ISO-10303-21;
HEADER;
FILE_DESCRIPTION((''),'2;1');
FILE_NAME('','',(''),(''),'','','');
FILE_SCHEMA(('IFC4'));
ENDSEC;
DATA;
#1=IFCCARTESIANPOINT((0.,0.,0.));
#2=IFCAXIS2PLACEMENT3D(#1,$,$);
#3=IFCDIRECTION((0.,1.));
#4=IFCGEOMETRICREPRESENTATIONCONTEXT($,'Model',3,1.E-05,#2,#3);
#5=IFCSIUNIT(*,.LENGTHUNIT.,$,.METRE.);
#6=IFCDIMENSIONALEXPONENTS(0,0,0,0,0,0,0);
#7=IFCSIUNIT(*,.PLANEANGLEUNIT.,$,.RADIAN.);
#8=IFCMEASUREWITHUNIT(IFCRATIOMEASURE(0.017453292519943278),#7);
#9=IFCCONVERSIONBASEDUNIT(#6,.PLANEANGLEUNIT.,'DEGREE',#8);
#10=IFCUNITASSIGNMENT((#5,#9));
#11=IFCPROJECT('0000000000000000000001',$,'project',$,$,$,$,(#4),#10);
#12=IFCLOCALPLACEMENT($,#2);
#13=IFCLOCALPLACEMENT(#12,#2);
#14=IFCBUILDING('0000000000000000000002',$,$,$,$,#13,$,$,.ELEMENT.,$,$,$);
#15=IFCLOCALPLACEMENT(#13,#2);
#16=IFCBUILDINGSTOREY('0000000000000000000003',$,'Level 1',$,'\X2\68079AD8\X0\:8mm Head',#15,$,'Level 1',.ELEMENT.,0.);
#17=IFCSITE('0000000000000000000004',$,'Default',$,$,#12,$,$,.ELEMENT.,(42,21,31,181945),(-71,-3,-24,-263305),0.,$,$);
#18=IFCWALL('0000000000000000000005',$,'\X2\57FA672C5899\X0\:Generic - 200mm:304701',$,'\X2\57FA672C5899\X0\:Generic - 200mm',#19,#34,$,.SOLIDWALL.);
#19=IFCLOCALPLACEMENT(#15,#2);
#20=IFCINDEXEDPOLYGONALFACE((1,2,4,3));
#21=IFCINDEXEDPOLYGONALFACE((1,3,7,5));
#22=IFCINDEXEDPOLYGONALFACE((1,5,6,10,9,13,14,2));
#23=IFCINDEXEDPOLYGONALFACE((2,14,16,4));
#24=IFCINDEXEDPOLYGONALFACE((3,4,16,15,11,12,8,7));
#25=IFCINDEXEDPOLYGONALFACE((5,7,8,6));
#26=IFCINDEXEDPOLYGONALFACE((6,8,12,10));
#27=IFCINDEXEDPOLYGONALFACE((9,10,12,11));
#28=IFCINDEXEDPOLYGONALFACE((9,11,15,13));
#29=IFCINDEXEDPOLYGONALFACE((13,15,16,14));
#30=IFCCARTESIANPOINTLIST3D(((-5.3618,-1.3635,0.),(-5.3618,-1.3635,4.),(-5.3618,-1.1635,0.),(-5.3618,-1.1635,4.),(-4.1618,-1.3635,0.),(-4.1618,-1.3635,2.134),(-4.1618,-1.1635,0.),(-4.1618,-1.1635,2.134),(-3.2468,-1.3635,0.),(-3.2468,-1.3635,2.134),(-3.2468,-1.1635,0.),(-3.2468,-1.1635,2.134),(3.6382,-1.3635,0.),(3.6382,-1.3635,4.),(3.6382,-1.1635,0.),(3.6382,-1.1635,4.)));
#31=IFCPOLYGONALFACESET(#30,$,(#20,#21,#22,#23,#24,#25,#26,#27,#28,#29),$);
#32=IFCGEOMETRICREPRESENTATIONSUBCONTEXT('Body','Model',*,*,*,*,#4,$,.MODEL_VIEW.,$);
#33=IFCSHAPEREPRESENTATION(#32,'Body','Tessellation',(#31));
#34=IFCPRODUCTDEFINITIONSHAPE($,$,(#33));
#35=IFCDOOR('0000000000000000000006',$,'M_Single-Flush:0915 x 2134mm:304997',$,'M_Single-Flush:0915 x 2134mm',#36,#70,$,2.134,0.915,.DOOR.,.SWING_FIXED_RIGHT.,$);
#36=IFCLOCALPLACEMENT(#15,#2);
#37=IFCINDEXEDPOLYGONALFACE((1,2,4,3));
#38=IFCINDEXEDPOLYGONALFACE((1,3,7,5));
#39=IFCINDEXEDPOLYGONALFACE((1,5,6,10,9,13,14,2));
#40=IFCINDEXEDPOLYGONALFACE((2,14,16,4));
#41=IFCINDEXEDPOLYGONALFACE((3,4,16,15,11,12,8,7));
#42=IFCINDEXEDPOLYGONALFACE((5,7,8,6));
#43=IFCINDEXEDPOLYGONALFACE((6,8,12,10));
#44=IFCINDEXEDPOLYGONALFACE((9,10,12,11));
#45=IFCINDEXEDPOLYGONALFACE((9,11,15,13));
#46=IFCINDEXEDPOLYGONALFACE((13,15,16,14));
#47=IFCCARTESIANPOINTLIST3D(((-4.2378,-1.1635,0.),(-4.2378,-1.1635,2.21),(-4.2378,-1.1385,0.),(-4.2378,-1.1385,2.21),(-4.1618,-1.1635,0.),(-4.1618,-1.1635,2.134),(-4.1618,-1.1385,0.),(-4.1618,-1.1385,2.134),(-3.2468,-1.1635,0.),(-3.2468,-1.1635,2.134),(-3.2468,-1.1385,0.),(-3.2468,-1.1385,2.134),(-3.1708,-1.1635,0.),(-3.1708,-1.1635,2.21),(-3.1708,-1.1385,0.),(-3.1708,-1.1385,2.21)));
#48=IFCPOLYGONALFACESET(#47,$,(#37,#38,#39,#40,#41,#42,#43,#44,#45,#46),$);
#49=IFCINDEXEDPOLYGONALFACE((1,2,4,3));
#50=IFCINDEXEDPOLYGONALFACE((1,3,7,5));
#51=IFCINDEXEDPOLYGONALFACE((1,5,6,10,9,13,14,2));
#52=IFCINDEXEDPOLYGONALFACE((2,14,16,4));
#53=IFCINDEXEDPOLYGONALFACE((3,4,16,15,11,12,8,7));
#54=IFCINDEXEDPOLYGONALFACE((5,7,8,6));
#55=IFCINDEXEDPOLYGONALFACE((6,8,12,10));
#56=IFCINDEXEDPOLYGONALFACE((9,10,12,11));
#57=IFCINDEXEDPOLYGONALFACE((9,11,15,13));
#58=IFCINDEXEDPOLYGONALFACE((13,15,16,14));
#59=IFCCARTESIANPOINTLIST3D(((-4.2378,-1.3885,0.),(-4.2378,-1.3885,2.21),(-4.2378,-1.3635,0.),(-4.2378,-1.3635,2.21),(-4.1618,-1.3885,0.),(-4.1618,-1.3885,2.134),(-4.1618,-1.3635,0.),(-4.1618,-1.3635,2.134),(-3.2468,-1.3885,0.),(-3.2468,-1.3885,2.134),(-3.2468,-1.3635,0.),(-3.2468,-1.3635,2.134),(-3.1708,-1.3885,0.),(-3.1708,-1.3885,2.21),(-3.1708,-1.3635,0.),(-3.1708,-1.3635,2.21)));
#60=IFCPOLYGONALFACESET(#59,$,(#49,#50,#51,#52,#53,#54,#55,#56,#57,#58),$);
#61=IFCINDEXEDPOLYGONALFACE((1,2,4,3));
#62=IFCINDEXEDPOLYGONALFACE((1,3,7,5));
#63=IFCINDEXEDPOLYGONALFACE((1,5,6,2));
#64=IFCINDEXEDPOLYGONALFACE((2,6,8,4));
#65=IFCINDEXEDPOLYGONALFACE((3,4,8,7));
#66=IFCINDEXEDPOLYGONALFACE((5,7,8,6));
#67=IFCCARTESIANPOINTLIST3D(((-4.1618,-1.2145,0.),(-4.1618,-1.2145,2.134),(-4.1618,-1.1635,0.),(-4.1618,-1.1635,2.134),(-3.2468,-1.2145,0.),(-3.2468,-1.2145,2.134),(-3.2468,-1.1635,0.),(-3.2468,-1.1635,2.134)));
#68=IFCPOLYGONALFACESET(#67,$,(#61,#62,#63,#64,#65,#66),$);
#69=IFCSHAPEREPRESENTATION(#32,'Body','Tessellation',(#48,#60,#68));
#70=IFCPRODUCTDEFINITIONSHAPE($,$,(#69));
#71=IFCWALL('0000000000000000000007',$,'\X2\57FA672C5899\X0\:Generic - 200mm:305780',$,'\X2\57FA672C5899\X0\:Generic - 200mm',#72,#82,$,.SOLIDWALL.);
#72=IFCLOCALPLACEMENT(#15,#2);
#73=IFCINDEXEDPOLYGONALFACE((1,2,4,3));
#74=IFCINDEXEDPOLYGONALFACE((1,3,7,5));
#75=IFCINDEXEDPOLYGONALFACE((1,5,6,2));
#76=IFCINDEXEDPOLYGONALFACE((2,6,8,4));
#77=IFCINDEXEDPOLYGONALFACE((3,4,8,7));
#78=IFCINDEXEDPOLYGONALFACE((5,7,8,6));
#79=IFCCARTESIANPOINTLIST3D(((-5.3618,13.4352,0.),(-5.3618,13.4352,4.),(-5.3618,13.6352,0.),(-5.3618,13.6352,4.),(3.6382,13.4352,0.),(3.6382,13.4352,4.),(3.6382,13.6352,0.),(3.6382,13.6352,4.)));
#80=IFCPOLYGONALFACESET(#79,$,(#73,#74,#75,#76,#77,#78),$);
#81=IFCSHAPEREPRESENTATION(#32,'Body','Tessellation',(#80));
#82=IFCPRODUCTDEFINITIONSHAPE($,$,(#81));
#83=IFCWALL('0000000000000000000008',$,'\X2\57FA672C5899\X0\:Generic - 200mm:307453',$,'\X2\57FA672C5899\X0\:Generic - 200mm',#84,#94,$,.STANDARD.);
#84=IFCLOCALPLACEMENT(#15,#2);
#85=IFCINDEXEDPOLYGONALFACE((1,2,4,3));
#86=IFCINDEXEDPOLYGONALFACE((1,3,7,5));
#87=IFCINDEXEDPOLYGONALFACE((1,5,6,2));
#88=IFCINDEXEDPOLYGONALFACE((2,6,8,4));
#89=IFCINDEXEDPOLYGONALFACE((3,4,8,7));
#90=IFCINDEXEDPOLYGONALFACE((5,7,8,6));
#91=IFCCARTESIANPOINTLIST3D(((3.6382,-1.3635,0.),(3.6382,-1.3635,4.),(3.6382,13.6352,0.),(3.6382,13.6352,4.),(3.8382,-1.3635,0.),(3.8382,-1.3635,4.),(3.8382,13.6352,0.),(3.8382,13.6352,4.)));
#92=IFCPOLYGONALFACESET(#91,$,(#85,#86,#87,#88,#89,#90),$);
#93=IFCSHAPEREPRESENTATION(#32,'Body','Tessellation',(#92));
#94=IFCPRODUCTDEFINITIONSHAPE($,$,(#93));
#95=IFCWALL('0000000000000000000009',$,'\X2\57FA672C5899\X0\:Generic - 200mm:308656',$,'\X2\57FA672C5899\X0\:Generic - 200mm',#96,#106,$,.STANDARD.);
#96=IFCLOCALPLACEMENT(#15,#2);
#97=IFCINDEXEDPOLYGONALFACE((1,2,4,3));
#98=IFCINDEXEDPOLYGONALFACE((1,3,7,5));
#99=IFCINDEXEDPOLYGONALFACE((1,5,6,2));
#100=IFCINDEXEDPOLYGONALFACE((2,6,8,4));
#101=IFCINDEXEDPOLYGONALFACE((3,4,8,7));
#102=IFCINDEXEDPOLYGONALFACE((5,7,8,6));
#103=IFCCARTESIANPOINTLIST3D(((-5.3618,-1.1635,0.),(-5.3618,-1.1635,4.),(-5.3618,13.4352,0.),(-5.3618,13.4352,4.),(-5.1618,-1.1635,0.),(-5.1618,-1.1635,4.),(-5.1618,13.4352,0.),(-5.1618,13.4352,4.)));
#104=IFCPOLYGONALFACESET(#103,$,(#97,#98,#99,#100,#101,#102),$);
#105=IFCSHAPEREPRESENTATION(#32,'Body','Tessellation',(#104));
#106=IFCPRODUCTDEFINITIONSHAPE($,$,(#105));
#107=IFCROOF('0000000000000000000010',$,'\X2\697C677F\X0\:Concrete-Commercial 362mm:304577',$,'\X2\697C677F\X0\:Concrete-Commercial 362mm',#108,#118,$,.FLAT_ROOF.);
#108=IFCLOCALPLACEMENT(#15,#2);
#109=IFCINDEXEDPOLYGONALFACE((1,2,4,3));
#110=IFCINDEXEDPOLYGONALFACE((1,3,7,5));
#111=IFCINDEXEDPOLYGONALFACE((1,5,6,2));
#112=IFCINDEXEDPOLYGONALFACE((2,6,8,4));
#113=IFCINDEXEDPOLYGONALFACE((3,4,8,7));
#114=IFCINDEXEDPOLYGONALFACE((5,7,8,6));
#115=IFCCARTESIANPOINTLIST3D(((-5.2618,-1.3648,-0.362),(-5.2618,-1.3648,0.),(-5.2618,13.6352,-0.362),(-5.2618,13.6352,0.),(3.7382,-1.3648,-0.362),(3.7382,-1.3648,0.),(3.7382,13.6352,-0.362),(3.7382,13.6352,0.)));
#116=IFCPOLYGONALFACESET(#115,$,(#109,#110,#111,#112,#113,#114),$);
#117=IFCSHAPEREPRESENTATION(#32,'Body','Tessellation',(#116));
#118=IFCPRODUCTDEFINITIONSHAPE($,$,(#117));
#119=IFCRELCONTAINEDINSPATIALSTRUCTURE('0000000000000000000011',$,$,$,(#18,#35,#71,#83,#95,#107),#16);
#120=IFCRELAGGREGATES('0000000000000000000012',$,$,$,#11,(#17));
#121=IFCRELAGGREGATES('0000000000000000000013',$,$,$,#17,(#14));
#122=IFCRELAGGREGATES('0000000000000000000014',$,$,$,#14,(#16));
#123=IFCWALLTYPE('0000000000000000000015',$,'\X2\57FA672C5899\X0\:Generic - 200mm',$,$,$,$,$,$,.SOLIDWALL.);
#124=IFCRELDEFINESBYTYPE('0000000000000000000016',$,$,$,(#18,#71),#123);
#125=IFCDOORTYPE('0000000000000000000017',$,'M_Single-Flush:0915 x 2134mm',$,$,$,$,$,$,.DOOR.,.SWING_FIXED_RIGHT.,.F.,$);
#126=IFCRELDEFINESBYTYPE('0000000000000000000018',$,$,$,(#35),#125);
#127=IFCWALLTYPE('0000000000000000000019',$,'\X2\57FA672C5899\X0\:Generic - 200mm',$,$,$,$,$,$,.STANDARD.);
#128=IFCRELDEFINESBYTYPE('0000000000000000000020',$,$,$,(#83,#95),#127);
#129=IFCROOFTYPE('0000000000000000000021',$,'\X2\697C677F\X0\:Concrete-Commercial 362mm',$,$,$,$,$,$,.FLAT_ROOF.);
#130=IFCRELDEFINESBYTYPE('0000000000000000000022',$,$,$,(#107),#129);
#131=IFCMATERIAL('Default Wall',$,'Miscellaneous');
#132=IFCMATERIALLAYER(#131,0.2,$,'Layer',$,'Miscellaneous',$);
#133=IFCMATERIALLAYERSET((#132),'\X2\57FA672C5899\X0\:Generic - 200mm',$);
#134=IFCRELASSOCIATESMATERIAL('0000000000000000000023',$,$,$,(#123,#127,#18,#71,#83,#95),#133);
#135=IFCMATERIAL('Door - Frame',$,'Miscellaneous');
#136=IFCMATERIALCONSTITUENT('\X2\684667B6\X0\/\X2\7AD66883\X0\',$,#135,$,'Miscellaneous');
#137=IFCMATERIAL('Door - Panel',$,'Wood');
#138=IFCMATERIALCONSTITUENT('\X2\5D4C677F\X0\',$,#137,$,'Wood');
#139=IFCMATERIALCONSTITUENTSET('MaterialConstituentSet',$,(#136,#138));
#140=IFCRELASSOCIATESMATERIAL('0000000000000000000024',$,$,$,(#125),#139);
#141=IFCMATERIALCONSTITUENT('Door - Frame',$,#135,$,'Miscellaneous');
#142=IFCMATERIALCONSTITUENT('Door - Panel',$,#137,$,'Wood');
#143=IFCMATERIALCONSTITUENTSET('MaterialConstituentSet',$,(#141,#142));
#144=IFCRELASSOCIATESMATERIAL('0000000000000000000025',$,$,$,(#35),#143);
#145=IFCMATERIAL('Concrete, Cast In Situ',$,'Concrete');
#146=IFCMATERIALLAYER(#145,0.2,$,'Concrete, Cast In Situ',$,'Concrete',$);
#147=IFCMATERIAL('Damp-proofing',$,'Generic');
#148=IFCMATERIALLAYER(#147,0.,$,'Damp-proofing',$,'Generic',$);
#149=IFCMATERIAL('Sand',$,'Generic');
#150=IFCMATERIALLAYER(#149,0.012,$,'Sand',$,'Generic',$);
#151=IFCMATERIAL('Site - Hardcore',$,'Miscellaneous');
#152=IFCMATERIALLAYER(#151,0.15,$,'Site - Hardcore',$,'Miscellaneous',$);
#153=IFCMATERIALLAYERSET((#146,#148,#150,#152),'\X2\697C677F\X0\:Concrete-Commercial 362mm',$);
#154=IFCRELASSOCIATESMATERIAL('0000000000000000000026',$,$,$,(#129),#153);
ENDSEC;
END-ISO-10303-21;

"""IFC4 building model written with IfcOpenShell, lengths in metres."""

from ifc_helpers import new_model, entity, si_unit, converted_unit, direction, frame, frame_2d, origin, origin_2d_with_axis, place, context, subcontext, project, spatial, polyline, rectangle, outline, extrude, source, transform, mapped, material, layer, layer_set, layer_usage, constituent, constituent_set, type_object, type_shapes, element, fill, save


model = new_model("IFC4")

# Units and contexts
model_context = context("Model", 3, precision=1e-05, world=origin(), true_north=direction((0.0, 1.0)))
body_context = subcontext(model_context, "Body", "Model", "MODEL_VIEW")
ifc_project = project(units=[si_unit("LENGTHUNIT", "METRE"), converted_unit("PLANEANGLEUNIT", "DEGREE", entity("IfcRatioMeasure", 0.017453292519943278), si_unit("PLANEANGLEUNIT", "RADIAN"), dimensions=[0, 0, 0, 0, 0, 0, 0])], contexts=[model_context])

# Site, building, storey
site_placement = place(None, origin())
site = spatial("IfcSite", under=ifc_project, at=site_placement, Name="Default", CompositionType="ELEMENT", RefLatitude=(42, 21, 31, 181945), RefLongitude=(-71, -3, -24, -263305), RefElevation=0.0)
building_placement = place(site_placement, origin())
building = spatial("IfcBuilding", under=site, at=building_placement, CompositionType="ELEMENT")
storey_placement = place(building_placement, origin())
storey = spatial("IfcBuildingStorey", under=building, at=storey_placement, Name="Level 1", ObjectType="标高:8mm Head", LongName="Level 1", CompositionType="ELEMENT", Elevation=0.0)

# Wall, opening, door
ifc_material_1 = material(Name="Default Wall", Category="Miscellaneous")
ifc_layer_1 = layer(ifc_material_1, 0.2, Name="Layer", Category="Miscellaneous")
ifc_layer_set_1 = layer_set([ifc_layer_1], Name="基本墙:Generic - 200mm")
ifc_layer_usage_1 = layer_usage(ifc_layer_set_1, "AXIS2", "NEGATIVE", 0.1)
wall_type_1 = type_object("IfcWallType", Name="基本墙:Generic - 200mm", PredefinedType="SOLIDWALL", material=ifc_layer_set_1)
wall_1_placement = place(storey_placement, frame((-5.3618, -1.2635, 0.0)))
wall_1 = element("IfcWall", 1, at=wall_1_placement, inside=storey, type_object=wall_type_1, material=ifc_layer_usage_1, Name="基本墙:Generic - 200mm:304701", ObjectType="基本墙:Generic - 200mm", PredefinedType="SOLIDWALL", context=body_context, shape_type="SweptSolid", body=[
    extrude(rectangle(XDim=9.0, YDim=0.2, at=frame_2d((4.5, 0.0), x_axis=(1.0, 0.0))), origin(), (0.0, 0.0, 1.0), 4.0),
])
opening_placement = place(wall_1_placement, frame((1.2, -0.1, 0.0)))
opening = element("IfcOpeningElement", 2, at=opening_placement, cuts=wall_1, PredefinedType="OPENING", context=body_context, shape_type="SweptSolid", body=[
    extrude(rectangle(XDim=0.915, YDim=2.134, at=frame_2d((1.067, 0.4575), x_axis=(0.0, 1.0))), frame((0.0, 0.0, 0.0), z_axis=(0.0, 1.0, 0.0), x_axis=(0.0, 0.0, 1.0)), (0.0, 0.0, 1.0), 0.2),
])
ifc_material_2 = material(Name="Door - Frame", Category="Miscellaneous")
ifc_constituent_1 = constituent(ifc_material_2, Name="Door - Frame", Category="Miscellaneous")
ifc_material_3 = material(Name="Door - Panel", Category="Wood")
ifc_constituent_2 = constituent(ifc_material_3, Name="Door - Panel", Category="Wood")
ifc_constituent_set_1 = constituent_set(constituents=[ifc_constituent_1, ifc_constituent_2], Name="MaterialConstituentSet")
ifc_constituent_3 = constituent(ifc_material_2, Name="框架/竖梃", Category="Miscellaneous")
ifc_constituent_4 = constituent(ifc_material_3, Name="嵌板", Category="Wood")
ifc_constituent_set_2 = constituent_set(constituents=[ifc_constituent_3, ifc_constituent_4], Name="MaterialConstituentSet")
door_type = type_object("IfcDoorType", Name="M_Single-Flush:0915 x 2134mm", OperationType="SWING_FIXED_RIGHT", ParameterTakesPrecedence=False, PredefinedType="DOOR", material=ifc_constituent_set_2)
shared_shape_1 = source(origin(), body_context, "Body", "SweptSolid", [
    extrude(outline(polyline([(-0.5335, -1.124), (0.5335, -1.124), (0.5335, 1.086), (0.4575, 1.086), (0.4575, -1.048), (-0.4575, -1.048), (-0.4575, 1.086), (-0.5335, 1.086), (-0.5335, -1.124)])), frame((0.4575, 0.2, 1.086), z_axis=(0.0, 1.0, 0.0), x_axis=(1.0, 0.0, 0.0)), (0.0, 0.0, 1.0), 0.025),
    extrude(outline(polyline([(-1.124, -0.5335), (1.086, -0.5335), (1.086, -0.4575), (-1.048, -0.4575), (-1.048, 0.4575), (1.086, 0.4575), (1.086, 0.5335), (-1.124, 0.5335), (-1.124, -0.5335)])), frame((0.4575, -0.025, 1.086), z_axis=(0.0, 1.0, 0.0), x_axis=(0.0, 0.0, -1.0)), (0.0, 0.0, 1.0), 0.025),
    extrude(rectangle(XDim=0.051, YDim=0.915, at=frame_2d((0.0, 0.0), x_axis=(1.0, 0.0))), frame((0.4575, 0.1745, 0.0), z_axis=(0.0, 0.0, 1.0), x_axis=(0.0, 1.0, 0.0)), (0.0, 0.0, 1.0), 2.134),
])
type_shapes(door_type, [shared_shape_1])
door_placement = place(opening_placement, origin())
door = element("IfcDoor", 3, at=door_placement, inside=storey, type_object=door_type, material=ifc_constituent_set_1, Name="M_Single-Flush:0915 x 2134mm:304997", ObjectType="M_Single-Flush:0915 x 2134mm", OperationType="SWING_FIXED_RIGHT", OverallHeight=2.134, OverallWidth=0.915, PredefinedType="DOOR", context=body_context, shape_type="MappedRepresentation", body=[
    mapped(shared_shape_1, transform((0.0, 0.0, 0.0), scale=1.0)),
])
fill(opening, door)

# Walls
ifc_layer_usage_2 = layer_usage(ifc_layer_set_1, "AXIS2", "NEGATIVE", 0.1)
wall_2_placement = place(storey_placement, frame((-5.3618, 13.5352, 0.0)))
element("IfcWall", 4, at=wall_2_placement, inside=storey, type_object=wall_type_1, material=ifc_layer_usage_2, Name="基本墙:Generic - 200mm:305780", ObjectType="基本墙:Generic - 200mm", PredefinedType="SOLIDWALL", context=body_context, shape_type="SweptSolid", body=[
    extrude(rectangle(XDim=9.0, YDim=0.2, at=frame_2d((4.5, 0.0), x_axis=(-1.0, 0.0))), origin(), (0.0, 0.0, 1.0), 4.0),
])
ifc_layer_usage_3 = layer_usage(ifc_layer_set_1, "AXIS2", "NEGATIVE", 0.1)
wall_type_2 = type_object("IfcWallType", Name="基本墙:Generic - 200mm", PredefinedType="STANDARD", material=ifc_layer_set_1)
wall_3_placement = place(storey_placement, frame((3.7382, -1.3635, 0.0), z_axis=(0.0, 0.0, 1.0), x_axis=(0.0, 1.0, 0.0)))
element("IfcWall", 5, at=wall_3_placement, inside=storey, type_object=wall_type_2, material=ifc_layer_usage_3, Name="基本墙:Generic - 200mm:307453", ObjectType="基本墙:Generic - 200mm", PredefinedType="STANDARD", context=body_context, shape_type="SweptSolid", body=[
    extrude(rectangle(XDim=14.9987, YDim=0.2, at=frame_2d((7.4993, 0.0), x_axis=(-1.0, 0.0))), origin(), (0.0, 0.0, 1.0), 4.0),
])
ifc_layer_usage_4 = layer_usage(ifc_layer_set_1, "AXIS2", "NEGATIVE", 0.1)
wall_4_placement = place(storey_placement, frame((-5.2618, 13.4352, 0.0), z_axis=(0.0, 0.0, 1.0), x_axis=(0.0, -1.0, 0.0)))
element("IfcWall", 6, at=wall_4_placement, inside=storey, type_object=wall_type_2, material=ifc_layer_usage_4, Name="基本墙:Generic - 200mm:308656", ObjectType="基本墙:Generic - 200mm", PredefinedType="STANDARD", context=body_context, shape_type="SweptSolid", body=[
    extrude(rectangle(XDim=14.5987, YDim=0.2, at=frame_2d((7.2993, 0.0), x_axis=(-1.0, 0.0))), origin(), (0.0, 0.0, 1.0), 4.0),
])

# Roof
ifc_material_4 = material(Name="Concrete, Cast In Situ", Category="Concrete")
ifc_layer_2 = layer(ifc_material_4, 0.2, Name="Concrete, Cast In Situ", Category="Concrete")
ifc_material_5 = material(Name="Damp-proofing", Category="Generic")
ifc_layer_3 = layer(ifc_material_5, 0.0, Name="Damp-proofing", Category="Generic")
ifc_material_6 = material(Name="Sand", Category="Generic")
ifc_layer_4 = layer(ifc_material_6, 0.012, Name="Sand", Category="Generic")
ifc_material_7 = material(Name="Site - Hardcore", Category="Miscellaneous")
ifc_layer_5 = layer(ifc_material_7, 0.15, Name="Site - Hardcore", Category="Miscellaneous")
ifc_layer_set_2 = layer_set([ifc_layer_2, ifc_layer_3, ifc_layer_4, ifc_layer_5], Name="楼板:Concrete-Commercial 362mm")
roof_type = type_object("IfcRoofType", Name="楼板:Concrete-Commercial 362mm", PredefinedType="FLAT_ROOF", material=ifc_layer_set_2)
roof_placement = place(storey_placement, origin())
element("IfcRoof", 7, at=roof_placement, inside=storey, type_object=roof_type, Name="楼板:Concrete-Commercial 362mm:304577", ObjectType="楼板:Concrete-Commercial 362mm", PredefinedType="FLAT_ROOF", context=body_context, shape_type="SweptSolid", body=[
    extrude(rectangle(XDim=15.0, YDim=9.0, at=origin_2d_with_axis()), frame((-0.7618, 6.1352, 0.0), z_axis=(0.0, 0.0, -1.0), x_axis=(0.0, 1.0, 0.0)), (0.0, 0.0, 1.0), 0.362),
])

save(model, "model.ifc")
